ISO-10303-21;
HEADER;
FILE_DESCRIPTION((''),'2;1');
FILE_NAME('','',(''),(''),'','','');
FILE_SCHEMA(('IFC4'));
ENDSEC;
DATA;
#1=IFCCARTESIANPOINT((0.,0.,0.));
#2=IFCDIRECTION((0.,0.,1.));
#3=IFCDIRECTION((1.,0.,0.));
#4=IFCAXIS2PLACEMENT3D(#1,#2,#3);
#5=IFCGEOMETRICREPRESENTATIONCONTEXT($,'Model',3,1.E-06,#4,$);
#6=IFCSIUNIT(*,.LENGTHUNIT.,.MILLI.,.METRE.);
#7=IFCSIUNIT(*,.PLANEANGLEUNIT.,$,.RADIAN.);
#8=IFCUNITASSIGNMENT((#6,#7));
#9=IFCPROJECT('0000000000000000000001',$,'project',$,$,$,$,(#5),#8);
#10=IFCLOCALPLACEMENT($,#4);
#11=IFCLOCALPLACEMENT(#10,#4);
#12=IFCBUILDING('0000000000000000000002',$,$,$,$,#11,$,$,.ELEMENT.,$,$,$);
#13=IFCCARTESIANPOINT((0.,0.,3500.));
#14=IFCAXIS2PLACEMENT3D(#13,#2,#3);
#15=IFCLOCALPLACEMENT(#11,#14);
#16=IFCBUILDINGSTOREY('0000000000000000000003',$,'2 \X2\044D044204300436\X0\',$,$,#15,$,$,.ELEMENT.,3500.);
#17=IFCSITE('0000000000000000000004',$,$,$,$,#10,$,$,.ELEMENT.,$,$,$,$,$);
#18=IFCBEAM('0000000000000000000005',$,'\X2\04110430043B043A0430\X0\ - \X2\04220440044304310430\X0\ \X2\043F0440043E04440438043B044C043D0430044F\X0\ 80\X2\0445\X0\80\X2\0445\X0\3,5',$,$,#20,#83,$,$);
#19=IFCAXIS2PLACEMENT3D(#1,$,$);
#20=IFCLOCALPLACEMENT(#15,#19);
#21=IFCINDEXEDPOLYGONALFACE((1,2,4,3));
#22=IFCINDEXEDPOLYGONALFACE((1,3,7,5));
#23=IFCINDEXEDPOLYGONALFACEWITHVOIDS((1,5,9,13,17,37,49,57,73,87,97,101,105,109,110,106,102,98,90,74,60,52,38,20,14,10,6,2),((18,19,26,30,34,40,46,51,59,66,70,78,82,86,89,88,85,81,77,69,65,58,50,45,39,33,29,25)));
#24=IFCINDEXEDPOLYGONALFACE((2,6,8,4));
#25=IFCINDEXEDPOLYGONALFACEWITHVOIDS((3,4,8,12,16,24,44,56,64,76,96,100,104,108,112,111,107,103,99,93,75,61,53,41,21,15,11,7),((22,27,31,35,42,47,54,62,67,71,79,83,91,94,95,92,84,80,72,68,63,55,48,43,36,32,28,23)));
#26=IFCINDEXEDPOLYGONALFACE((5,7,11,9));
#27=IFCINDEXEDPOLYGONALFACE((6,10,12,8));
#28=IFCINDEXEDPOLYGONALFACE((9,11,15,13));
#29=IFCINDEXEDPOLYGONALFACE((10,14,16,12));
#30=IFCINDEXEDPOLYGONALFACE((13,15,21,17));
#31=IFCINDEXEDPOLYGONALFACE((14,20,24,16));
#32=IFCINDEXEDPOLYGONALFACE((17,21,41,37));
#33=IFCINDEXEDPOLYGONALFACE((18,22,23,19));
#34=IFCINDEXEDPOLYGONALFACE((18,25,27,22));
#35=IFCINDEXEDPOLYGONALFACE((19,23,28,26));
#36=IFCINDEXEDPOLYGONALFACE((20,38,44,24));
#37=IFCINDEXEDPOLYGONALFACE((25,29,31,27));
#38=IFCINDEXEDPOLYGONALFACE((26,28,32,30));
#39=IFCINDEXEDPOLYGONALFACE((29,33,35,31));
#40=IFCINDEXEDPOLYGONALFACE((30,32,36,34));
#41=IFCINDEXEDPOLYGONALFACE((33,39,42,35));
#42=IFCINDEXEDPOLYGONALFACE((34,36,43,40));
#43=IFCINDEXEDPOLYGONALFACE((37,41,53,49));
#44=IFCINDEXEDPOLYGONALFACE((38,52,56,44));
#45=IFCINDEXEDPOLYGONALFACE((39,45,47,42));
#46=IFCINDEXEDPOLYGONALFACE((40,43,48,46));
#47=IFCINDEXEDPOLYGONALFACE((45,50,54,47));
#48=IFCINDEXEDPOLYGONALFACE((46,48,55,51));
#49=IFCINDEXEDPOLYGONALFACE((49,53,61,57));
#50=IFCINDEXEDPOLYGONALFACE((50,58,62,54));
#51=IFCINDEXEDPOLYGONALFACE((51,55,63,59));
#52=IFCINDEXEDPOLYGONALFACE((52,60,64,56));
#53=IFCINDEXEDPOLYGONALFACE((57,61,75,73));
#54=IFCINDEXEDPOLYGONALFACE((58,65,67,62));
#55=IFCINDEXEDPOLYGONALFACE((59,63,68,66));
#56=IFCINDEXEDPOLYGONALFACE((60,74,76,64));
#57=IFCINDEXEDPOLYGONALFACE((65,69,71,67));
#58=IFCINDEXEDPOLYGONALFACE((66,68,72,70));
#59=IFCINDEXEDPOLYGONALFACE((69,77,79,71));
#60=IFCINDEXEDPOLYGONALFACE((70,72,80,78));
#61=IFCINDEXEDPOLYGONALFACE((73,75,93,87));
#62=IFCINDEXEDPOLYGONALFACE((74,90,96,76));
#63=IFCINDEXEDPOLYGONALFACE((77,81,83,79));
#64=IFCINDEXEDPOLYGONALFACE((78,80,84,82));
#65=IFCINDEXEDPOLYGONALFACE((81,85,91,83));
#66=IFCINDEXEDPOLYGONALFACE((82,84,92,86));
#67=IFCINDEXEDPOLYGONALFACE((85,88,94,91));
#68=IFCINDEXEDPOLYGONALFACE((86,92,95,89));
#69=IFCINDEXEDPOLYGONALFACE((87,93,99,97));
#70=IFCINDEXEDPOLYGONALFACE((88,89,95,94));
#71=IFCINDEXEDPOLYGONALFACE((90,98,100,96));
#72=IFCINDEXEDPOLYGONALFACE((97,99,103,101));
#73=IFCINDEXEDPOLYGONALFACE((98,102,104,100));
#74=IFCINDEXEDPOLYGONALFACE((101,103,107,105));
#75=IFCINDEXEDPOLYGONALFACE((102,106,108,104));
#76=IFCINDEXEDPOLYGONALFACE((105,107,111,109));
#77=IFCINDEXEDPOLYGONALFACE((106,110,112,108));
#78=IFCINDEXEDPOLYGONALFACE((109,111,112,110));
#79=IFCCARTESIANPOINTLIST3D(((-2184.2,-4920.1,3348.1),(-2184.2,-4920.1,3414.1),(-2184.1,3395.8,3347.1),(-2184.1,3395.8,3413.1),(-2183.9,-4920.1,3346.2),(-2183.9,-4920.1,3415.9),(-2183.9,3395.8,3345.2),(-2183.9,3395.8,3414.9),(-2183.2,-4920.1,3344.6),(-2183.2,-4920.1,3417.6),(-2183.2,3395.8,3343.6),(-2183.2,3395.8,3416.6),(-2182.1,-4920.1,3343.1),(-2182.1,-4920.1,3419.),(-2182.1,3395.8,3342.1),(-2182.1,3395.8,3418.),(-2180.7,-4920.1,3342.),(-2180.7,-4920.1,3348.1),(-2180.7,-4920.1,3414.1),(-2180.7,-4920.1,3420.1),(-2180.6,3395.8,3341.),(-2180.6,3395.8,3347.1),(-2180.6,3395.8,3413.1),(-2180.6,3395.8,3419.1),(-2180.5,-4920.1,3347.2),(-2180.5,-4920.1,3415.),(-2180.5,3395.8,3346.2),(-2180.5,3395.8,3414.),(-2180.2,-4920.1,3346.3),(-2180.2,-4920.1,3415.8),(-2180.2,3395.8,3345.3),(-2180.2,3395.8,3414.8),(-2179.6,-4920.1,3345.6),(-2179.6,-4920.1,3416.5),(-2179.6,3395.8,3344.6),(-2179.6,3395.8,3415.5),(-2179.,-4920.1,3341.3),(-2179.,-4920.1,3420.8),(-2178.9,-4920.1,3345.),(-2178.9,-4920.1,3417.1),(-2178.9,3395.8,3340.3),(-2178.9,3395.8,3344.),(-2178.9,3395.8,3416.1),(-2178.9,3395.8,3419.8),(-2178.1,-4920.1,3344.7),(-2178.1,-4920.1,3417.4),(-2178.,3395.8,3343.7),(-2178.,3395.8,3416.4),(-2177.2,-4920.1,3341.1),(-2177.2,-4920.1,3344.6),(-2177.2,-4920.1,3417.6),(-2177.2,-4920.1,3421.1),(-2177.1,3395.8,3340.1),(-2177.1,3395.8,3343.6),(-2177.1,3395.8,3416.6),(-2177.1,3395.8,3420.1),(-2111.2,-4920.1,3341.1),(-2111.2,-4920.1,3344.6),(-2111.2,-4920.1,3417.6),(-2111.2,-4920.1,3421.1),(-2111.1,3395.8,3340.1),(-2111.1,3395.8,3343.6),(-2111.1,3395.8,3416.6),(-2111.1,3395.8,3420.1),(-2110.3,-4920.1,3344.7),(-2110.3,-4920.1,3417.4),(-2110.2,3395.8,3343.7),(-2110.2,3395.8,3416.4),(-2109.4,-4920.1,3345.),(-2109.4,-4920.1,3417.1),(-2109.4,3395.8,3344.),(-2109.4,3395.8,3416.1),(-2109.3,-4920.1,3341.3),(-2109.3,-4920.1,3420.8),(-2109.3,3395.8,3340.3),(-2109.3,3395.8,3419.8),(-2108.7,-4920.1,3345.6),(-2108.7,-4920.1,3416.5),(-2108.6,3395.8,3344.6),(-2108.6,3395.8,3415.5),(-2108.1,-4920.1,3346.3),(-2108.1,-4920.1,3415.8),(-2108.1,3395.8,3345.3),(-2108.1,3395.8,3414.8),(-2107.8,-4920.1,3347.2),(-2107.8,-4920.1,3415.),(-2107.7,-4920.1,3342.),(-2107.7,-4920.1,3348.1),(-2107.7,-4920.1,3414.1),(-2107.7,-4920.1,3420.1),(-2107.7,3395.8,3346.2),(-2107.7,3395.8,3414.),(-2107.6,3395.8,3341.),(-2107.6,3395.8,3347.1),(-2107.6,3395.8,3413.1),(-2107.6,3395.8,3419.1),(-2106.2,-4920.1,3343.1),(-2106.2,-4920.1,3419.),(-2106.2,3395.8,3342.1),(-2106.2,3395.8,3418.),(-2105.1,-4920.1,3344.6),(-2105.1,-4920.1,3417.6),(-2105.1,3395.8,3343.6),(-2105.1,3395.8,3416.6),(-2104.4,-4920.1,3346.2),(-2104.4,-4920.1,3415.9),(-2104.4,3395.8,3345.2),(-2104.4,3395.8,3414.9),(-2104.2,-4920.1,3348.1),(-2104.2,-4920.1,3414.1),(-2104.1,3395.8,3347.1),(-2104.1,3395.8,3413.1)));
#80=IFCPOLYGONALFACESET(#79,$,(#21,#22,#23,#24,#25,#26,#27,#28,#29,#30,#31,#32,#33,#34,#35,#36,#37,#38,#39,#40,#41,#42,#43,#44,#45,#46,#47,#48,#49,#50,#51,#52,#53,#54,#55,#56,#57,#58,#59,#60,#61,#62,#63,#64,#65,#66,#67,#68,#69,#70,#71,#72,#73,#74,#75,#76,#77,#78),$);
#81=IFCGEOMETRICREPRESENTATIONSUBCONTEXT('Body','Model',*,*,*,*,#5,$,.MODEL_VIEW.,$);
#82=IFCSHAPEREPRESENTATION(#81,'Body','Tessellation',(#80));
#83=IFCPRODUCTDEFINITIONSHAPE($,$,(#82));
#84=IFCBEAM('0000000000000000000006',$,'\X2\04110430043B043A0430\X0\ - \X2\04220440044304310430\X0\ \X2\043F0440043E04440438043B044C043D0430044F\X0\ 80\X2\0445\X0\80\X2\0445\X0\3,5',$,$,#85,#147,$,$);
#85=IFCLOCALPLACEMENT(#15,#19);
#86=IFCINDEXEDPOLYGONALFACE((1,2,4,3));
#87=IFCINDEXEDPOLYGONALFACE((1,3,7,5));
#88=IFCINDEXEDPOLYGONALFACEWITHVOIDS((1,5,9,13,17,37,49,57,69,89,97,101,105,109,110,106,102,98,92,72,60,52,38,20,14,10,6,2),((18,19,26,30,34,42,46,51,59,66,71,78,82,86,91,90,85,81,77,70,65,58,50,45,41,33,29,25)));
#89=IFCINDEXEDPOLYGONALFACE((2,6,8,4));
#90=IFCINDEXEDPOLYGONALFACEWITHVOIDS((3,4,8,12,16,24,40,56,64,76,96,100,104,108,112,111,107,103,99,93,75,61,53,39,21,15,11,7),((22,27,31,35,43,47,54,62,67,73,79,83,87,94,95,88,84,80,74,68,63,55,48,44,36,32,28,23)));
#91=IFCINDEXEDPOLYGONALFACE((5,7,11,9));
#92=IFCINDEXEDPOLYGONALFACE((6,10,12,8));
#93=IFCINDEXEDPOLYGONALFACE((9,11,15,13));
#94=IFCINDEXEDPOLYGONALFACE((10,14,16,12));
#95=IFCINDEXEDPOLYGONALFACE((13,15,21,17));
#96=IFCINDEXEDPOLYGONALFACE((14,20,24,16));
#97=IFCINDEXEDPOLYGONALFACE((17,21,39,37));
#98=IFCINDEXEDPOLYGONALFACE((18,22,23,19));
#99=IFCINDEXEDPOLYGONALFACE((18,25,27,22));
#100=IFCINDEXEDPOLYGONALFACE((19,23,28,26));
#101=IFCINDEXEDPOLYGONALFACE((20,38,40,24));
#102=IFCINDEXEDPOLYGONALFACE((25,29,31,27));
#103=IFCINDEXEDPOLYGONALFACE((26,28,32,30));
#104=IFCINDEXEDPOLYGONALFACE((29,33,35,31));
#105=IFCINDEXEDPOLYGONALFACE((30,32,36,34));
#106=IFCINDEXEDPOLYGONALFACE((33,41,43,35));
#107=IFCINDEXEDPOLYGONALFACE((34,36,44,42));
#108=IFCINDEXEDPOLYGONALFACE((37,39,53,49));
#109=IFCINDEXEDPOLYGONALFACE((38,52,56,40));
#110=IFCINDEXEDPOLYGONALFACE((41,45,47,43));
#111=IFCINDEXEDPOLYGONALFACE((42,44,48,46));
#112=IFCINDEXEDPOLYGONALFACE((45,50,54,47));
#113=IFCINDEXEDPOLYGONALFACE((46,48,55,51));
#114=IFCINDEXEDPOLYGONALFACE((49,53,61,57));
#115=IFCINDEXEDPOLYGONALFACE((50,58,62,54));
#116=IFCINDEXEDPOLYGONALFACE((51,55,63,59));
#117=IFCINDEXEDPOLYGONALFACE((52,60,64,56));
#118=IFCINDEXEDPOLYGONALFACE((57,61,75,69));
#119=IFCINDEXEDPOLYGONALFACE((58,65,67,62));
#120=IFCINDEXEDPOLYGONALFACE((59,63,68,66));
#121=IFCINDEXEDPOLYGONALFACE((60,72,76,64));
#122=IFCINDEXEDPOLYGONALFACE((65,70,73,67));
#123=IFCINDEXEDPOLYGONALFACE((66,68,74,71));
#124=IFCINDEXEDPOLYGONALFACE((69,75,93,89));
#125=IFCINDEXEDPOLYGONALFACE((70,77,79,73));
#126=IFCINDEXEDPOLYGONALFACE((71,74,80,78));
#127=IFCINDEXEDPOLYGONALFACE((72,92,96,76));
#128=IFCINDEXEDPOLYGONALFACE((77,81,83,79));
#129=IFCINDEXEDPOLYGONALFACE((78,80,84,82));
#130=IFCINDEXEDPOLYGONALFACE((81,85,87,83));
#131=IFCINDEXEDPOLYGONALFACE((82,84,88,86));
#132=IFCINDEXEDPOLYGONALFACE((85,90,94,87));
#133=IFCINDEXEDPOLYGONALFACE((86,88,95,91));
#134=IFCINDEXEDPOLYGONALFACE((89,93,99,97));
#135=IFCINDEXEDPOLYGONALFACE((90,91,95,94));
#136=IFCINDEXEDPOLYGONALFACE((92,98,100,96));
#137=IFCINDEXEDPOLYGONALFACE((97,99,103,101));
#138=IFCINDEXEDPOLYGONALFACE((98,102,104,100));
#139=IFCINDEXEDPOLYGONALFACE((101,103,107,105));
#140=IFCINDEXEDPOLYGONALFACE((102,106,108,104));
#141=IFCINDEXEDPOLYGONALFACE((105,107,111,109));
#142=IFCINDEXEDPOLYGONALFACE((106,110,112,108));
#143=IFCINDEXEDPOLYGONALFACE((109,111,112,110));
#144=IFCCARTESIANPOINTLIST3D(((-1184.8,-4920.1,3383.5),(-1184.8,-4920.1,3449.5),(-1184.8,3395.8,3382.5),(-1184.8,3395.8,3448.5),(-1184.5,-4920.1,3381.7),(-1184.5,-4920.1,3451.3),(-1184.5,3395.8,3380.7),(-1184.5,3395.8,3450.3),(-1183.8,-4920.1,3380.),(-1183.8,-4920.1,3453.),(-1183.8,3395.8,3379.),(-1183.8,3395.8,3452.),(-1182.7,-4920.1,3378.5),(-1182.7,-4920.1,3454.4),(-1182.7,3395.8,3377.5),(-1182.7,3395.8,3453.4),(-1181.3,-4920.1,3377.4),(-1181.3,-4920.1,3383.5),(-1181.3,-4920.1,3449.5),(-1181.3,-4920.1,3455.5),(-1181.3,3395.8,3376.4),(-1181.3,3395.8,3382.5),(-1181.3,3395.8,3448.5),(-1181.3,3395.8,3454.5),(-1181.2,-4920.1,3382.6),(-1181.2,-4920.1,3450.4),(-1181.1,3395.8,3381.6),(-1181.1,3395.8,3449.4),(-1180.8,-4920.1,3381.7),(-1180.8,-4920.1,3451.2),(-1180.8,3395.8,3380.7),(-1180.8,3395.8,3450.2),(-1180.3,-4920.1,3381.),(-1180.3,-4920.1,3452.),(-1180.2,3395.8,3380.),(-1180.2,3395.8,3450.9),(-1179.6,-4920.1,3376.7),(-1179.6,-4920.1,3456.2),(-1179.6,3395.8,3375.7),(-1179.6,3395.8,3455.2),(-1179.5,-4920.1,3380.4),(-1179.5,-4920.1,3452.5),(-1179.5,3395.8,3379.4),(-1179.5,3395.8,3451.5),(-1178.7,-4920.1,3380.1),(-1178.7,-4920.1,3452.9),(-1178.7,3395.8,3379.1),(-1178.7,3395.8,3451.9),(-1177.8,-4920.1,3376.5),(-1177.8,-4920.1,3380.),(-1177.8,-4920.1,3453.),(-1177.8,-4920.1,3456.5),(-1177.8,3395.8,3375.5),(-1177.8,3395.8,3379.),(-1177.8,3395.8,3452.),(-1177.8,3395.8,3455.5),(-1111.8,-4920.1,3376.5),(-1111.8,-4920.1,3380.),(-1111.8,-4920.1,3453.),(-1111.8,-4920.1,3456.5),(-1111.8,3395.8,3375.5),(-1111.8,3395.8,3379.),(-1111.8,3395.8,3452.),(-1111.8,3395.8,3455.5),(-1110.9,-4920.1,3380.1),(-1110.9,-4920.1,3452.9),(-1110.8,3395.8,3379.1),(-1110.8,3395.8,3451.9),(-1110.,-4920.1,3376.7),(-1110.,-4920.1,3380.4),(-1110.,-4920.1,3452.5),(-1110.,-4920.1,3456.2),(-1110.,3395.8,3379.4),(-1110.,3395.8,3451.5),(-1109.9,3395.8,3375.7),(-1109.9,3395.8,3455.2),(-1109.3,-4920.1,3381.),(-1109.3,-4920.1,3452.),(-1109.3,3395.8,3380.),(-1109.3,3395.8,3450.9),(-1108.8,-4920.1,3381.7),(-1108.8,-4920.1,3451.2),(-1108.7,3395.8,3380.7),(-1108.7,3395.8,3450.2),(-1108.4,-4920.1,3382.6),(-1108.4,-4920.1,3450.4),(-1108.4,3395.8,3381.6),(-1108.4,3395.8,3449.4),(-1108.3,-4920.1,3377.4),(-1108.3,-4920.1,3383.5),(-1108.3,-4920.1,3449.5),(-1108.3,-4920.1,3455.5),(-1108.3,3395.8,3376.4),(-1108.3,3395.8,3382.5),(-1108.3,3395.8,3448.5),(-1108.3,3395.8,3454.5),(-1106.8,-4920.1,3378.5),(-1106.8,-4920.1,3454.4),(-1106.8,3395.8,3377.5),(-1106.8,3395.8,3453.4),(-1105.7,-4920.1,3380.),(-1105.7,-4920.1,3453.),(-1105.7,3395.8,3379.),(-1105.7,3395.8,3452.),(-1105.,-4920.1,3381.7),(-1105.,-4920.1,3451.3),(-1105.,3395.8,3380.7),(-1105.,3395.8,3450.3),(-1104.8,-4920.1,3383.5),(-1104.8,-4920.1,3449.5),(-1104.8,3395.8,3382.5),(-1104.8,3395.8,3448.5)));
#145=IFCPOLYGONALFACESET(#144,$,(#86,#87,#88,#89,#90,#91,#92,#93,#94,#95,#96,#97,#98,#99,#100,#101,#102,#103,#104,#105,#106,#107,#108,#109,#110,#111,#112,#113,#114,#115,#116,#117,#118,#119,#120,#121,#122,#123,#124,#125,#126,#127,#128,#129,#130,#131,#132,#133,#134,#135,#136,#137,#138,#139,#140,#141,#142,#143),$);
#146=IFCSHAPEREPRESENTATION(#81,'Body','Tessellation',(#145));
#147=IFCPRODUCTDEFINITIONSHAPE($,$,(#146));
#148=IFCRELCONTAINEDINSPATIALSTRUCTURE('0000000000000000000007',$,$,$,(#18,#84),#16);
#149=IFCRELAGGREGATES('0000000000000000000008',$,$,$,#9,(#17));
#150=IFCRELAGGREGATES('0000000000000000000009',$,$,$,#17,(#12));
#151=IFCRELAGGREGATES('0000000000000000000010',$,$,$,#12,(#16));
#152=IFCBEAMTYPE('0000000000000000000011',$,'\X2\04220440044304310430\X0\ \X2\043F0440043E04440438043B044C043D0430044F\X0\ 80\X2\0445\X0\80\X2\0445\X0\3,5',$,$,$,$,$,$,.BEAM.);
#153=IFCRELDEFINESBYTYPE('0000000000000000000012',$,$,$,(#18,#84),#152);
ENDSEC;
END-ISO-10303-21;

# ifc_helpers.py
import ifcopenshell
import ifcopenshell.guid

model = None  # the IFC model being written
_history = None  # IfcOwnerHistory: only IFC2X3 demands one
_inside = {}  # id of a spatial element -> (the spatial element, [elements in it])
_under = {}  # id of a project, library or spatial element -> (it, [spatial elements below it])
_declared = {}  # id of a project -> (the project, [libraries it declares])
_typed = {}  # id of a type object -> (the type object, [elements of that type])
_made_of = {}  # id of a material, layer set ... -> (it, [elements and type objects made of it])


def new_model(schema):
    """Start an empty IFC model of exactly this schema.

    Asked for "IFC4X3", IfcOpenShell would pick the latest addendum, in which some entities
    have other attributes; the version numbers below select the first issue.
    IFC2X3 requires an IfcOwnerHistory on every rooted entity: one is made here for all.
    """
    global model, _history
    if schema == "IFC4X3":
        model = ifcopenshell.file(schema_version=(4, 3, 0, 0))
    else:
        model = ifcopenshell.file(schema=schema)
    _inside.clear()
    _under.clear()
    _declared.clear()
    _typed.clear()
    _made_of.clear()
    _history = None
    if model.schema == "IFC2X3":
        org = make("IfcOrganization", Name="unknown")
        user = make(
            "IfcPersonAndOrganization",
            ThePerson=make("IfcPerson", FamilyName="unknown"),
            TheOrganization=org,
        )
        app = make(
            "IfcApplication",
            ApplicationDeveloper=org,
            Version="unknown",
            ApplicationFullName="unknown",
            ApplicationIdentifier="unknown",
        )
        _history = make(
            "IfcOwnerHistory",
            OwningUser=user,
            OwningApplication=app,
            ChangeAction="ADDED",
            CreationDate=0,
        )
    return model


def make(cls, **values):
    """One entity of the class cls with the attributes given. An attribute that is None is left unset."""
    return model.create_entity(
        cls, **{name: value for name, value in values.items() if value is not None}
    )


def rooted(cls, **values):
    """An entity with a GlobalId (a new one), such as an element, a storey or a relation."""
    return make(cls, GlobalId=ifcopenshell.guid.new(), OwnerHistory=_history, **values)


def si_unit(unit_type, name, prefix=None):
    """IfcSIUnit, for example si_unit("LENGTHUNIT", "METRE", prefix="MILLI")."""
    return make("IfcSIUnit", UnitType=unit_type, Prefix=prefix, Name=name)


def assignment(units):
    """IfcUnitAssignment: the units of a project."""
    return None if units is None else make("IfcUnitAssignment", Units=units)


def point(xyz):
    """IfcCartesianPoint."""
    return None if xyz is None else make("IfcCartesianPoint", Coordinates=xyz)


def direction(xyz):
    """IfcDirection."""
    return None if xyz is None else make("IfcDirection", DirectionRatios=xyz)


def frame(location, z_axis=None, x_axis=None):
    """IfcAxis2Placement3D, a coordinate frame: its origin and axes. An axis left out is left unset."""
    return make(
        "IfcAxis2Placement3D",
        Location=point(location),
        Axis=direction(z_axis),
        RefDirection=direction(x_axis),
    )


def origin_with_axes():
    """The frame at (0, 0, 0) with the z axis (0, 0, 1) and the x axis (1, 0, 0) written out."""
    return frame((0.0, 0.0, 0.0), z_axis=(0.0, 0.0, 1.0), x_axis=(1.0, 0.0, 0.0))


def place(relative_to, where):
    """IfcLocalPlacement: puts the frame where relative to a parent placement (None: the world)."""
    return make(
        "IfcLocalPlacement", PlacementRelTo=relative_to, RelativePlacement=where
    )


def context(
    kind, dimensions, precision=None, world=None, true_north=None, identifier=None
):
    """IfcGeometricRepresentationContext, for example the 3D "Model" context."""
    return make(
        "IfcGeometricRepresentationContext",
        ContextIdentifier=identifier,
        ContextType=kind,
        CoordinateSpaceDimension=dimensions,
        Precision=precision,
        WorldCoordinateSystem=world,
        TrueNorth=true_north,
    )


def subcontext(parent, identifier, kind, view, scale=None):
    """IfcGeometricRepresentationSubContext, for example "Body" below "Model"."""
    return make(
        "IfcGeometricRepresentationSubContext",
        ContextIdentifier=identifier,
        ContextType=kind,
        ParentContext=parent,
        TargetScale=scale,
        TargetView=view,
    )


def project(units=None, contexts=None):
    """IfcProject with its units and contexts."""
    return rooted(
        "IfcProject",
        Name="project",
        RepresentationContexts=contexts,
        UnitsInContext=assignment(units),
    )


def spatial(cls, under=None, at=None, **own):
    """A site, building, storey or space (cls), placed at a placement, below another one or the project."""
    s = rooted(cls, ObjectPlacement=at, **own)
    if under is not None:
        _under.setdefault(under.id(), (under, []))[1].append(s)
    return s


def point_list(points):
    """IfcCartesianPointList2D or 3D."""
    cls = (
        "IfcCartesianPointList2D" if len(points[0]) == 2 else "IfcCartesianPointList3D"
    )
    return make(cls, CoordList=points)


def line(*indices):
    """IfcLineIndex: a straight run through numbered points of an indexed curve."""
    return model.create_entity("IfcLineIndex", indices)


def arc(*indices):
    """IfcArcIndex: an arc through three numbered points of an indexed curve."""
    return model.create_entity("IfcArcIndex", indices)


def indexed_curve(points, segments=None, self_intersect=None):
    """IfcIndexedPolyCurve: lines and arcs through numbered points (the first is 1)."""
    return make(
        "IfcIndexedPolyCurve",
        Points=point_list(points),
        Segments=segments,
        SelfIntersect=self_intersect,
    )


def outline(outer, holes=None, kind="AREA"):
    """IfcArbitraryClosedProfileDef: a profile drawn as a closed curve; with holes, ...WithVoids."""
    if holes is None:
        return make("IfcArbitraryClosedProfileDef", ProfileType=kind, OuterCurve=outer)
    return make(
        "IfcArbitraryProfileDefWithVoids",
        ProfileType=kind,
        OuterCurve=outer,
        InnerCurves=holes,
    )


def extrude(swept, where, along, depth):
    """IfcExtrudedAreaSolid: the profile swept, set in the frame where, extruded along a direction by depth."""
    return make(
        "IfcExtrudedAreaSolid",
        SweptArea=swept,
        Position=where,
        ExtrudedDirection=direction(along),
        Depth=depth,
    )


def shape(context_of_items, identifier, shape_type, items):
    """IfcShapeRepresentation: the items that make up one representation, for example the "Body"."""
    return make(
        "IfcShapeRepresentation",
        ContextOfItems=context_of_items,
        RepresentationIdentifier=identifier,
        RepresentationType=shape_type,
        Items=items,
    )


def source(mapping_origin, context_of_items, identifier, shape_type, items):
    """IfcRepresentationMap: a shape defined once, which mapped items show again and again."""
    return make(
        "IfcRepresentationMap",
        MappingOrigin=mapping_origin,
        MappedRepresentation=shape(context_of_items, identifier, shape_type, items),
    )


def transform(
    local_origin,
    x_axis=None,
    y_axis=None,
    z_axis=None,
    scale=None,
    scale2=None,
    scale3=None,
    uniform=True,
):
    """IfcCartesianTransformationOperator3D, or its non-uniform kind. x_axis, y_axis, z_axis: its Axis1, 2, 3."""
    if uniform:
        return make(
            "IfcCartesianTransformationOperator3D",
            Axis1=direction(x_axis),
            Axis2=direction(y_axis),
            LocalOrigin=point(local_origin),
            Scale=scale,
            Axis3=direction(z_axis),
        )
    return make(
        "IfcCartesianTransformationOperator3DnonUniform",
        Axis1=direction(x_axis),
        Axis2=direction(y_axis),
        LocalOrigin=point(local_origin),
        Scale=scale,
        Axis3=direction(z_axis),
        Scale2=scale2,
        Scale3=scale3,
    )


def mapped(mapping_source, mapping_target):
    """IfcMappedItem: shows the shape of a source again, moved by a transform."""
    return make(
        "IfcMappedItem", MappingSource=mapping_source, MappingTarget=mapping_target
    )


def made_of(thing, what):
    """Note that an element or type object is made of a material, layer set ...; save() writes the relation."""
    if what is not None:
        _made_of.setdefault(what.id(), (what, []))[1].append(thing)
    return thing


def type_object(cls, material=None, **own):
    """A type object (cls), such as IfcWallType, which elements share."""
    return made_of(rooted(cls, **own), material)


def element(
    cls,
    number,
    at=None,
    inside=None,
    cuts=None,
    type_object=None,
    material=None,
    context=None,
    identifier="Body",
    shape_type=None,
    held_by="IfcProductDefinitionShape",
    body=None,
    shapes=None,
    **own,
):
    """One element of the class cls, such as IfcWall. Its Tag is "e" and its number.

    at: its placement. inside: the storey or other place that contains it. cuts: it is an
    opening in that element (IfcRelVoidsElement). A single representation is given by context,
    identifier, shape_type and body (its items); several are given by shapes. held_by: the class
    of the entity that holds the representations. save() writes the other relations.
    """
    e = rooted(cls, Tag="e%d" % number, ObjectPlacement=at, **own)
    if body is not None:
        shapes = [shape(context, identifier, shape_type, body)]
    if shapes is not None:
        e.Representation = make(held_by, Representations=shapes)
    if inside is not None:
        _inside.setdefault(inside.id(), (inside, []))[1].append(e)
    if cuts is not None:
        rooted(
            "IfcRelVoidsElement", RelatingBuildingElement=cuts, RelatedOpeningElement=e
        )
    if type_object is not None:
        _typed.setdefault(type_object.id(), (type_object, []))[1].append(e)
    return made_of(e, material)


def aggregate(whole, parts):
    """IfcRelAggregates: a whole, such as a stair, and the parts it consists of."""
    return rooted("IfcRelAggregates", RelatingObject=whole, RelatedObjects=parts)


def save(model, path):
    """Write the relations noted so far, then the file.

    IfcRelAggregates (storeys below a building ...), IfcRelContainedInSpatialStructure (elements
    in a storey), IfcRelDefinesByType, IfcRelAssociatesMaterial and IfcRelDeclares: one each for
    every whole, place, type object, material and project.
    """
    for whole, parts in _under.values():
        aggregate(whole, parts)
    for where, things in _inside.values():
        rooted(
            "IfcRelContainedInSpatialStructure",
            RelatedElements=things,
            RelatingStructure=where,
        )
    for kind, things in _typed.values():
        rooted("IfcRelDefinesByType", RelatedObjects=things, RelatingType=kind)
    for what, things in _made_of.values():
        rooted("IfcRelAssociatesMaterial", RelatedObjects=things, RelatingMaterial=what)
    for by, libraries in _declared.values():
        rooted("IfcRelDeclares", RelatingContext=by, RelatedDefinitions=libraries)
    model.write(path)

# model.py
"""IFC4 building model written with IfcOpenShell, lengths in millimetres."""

from ifc_helpers import new_model, si_unit, frame, origin_with_axes, place, context, subcontext, project, spatial, line, arc, indexed_curve, outline, extrude, source, transform, mapped, type_object, element, save


model = new_model("IFC4")

# Units and contexts
model_context = context("Model", 3, precision=1e-06, world=origin_with_axes())
body_context = subcontext(model_context, "Body", "Model", "MODEL_VIEW")
ifc_project = project(units=[si_unit("LENGTHUNIT", "METRE", prefix="MILLI"), si_unit("PLANEANGLEUNIT", "RADIAN")], contexts=[model_context])

# Site, building, storey
site_placement = place(None, origin_with_axes())
site = spatial("IfcSite", under=ifc_project, at=site_placement, CompositionType="ELEMENT")
building_placement = place(site_placement, origin_with_axes())
building = spatial("IfcBuilding", under=site, at=building_placement, CompositionType="ELEMENT")
storey_placement = place(building_placement, frame((0.0, 0.0, 3500.0), z_axis=(0.0, 0.0, 1.0), x_axis=(1.0, 0.0, 0.0)))
storey = spatial("IfcBuildingStorey", under=building, at=storey_placement, Name="2 этаж", CompositionType="ELEMENT", Elevation=3500.0)

# Beams
beam_type = type_object("IfcBeamType", Name="Труба профильная 80х80х3,5", PredefinedType="BEAM")
shared_shape_1 = source(origin_with_axes(), body_context, "Body", "SweptSolid", [
    extrude(outline(indexed_curve([(-40.0, -73.0), (-37.9, -77.9), (-33.0, -80.0), (33.0, -80.0), (37.9, -77.9), (40.0, -73.0), (40.0, -7.0), (37.9, -2.1), (33.0, 0.0), (-33.0, 0.0), (-37.9, -2.1), (-40.0, -7.0)], segments=[arc(1, 2, 3), line(3, 4), arc(4, 5, 6), line(6, 7), arc(7, 8, 9), line(9, 10), arc(10, 11, 12), line(12, 1)]), holes=[indexed_curve([(-36.5, -7.0), (-35.5, -4.5), (-33.0, -3.5), (33.0, -3.5), (35.5, -4.5), (36.5, -7.0), (36.5, -73.0), (35.5, -75.5), (33.0, -76.5), (-33.0, -76.5), (-35.5, -75.5), (-36.5, -73.0)], segments=[arc(1, 2, 3), line(3, 4), arc(4, 5, 6), line(6, 7), arc(7, 8, 9), line(9, 10), arc(10, 11, 12), line(12, 1)])]), origin_with_axes(), (0.0, 0.0, -1.0), 8315.9),
])
for number, where, z_axis, x_axis, name in (
    (1, (-2144.1, 3395.8, 3420.1), (0.000004, 1.0, -0.000121), (-1.0, 0.000004, 0.0), "Балка - Труба профильная 80х80х3,5"),
    (2, (-1144.8, 3395.8, 3455.5), (0.000004, 1.0, -0.000121), (-1.0, 0.000004, 0.0), "Балка - Труба профильная 80х80х3,5"),
):
    element("IfcBeam", number, at=place(storey_placement, frame(where, z_axis=z_axis, x_axis=x_axis)), inside=storey, type_object=beam_type, Name=name, context=body_context, shape_type="MappedRepresentation", body=[
        mapped(shared_shape_1, transform((0.0, 0.0, 0.0), x_axis=(1.0, 0.0, 0.0), y_axis=(0.0, 1.0, 0.0), z_axis=(0.0, 0.0, 1.0), scale=1.0)),
    ])

save(model, "model.ifc")
